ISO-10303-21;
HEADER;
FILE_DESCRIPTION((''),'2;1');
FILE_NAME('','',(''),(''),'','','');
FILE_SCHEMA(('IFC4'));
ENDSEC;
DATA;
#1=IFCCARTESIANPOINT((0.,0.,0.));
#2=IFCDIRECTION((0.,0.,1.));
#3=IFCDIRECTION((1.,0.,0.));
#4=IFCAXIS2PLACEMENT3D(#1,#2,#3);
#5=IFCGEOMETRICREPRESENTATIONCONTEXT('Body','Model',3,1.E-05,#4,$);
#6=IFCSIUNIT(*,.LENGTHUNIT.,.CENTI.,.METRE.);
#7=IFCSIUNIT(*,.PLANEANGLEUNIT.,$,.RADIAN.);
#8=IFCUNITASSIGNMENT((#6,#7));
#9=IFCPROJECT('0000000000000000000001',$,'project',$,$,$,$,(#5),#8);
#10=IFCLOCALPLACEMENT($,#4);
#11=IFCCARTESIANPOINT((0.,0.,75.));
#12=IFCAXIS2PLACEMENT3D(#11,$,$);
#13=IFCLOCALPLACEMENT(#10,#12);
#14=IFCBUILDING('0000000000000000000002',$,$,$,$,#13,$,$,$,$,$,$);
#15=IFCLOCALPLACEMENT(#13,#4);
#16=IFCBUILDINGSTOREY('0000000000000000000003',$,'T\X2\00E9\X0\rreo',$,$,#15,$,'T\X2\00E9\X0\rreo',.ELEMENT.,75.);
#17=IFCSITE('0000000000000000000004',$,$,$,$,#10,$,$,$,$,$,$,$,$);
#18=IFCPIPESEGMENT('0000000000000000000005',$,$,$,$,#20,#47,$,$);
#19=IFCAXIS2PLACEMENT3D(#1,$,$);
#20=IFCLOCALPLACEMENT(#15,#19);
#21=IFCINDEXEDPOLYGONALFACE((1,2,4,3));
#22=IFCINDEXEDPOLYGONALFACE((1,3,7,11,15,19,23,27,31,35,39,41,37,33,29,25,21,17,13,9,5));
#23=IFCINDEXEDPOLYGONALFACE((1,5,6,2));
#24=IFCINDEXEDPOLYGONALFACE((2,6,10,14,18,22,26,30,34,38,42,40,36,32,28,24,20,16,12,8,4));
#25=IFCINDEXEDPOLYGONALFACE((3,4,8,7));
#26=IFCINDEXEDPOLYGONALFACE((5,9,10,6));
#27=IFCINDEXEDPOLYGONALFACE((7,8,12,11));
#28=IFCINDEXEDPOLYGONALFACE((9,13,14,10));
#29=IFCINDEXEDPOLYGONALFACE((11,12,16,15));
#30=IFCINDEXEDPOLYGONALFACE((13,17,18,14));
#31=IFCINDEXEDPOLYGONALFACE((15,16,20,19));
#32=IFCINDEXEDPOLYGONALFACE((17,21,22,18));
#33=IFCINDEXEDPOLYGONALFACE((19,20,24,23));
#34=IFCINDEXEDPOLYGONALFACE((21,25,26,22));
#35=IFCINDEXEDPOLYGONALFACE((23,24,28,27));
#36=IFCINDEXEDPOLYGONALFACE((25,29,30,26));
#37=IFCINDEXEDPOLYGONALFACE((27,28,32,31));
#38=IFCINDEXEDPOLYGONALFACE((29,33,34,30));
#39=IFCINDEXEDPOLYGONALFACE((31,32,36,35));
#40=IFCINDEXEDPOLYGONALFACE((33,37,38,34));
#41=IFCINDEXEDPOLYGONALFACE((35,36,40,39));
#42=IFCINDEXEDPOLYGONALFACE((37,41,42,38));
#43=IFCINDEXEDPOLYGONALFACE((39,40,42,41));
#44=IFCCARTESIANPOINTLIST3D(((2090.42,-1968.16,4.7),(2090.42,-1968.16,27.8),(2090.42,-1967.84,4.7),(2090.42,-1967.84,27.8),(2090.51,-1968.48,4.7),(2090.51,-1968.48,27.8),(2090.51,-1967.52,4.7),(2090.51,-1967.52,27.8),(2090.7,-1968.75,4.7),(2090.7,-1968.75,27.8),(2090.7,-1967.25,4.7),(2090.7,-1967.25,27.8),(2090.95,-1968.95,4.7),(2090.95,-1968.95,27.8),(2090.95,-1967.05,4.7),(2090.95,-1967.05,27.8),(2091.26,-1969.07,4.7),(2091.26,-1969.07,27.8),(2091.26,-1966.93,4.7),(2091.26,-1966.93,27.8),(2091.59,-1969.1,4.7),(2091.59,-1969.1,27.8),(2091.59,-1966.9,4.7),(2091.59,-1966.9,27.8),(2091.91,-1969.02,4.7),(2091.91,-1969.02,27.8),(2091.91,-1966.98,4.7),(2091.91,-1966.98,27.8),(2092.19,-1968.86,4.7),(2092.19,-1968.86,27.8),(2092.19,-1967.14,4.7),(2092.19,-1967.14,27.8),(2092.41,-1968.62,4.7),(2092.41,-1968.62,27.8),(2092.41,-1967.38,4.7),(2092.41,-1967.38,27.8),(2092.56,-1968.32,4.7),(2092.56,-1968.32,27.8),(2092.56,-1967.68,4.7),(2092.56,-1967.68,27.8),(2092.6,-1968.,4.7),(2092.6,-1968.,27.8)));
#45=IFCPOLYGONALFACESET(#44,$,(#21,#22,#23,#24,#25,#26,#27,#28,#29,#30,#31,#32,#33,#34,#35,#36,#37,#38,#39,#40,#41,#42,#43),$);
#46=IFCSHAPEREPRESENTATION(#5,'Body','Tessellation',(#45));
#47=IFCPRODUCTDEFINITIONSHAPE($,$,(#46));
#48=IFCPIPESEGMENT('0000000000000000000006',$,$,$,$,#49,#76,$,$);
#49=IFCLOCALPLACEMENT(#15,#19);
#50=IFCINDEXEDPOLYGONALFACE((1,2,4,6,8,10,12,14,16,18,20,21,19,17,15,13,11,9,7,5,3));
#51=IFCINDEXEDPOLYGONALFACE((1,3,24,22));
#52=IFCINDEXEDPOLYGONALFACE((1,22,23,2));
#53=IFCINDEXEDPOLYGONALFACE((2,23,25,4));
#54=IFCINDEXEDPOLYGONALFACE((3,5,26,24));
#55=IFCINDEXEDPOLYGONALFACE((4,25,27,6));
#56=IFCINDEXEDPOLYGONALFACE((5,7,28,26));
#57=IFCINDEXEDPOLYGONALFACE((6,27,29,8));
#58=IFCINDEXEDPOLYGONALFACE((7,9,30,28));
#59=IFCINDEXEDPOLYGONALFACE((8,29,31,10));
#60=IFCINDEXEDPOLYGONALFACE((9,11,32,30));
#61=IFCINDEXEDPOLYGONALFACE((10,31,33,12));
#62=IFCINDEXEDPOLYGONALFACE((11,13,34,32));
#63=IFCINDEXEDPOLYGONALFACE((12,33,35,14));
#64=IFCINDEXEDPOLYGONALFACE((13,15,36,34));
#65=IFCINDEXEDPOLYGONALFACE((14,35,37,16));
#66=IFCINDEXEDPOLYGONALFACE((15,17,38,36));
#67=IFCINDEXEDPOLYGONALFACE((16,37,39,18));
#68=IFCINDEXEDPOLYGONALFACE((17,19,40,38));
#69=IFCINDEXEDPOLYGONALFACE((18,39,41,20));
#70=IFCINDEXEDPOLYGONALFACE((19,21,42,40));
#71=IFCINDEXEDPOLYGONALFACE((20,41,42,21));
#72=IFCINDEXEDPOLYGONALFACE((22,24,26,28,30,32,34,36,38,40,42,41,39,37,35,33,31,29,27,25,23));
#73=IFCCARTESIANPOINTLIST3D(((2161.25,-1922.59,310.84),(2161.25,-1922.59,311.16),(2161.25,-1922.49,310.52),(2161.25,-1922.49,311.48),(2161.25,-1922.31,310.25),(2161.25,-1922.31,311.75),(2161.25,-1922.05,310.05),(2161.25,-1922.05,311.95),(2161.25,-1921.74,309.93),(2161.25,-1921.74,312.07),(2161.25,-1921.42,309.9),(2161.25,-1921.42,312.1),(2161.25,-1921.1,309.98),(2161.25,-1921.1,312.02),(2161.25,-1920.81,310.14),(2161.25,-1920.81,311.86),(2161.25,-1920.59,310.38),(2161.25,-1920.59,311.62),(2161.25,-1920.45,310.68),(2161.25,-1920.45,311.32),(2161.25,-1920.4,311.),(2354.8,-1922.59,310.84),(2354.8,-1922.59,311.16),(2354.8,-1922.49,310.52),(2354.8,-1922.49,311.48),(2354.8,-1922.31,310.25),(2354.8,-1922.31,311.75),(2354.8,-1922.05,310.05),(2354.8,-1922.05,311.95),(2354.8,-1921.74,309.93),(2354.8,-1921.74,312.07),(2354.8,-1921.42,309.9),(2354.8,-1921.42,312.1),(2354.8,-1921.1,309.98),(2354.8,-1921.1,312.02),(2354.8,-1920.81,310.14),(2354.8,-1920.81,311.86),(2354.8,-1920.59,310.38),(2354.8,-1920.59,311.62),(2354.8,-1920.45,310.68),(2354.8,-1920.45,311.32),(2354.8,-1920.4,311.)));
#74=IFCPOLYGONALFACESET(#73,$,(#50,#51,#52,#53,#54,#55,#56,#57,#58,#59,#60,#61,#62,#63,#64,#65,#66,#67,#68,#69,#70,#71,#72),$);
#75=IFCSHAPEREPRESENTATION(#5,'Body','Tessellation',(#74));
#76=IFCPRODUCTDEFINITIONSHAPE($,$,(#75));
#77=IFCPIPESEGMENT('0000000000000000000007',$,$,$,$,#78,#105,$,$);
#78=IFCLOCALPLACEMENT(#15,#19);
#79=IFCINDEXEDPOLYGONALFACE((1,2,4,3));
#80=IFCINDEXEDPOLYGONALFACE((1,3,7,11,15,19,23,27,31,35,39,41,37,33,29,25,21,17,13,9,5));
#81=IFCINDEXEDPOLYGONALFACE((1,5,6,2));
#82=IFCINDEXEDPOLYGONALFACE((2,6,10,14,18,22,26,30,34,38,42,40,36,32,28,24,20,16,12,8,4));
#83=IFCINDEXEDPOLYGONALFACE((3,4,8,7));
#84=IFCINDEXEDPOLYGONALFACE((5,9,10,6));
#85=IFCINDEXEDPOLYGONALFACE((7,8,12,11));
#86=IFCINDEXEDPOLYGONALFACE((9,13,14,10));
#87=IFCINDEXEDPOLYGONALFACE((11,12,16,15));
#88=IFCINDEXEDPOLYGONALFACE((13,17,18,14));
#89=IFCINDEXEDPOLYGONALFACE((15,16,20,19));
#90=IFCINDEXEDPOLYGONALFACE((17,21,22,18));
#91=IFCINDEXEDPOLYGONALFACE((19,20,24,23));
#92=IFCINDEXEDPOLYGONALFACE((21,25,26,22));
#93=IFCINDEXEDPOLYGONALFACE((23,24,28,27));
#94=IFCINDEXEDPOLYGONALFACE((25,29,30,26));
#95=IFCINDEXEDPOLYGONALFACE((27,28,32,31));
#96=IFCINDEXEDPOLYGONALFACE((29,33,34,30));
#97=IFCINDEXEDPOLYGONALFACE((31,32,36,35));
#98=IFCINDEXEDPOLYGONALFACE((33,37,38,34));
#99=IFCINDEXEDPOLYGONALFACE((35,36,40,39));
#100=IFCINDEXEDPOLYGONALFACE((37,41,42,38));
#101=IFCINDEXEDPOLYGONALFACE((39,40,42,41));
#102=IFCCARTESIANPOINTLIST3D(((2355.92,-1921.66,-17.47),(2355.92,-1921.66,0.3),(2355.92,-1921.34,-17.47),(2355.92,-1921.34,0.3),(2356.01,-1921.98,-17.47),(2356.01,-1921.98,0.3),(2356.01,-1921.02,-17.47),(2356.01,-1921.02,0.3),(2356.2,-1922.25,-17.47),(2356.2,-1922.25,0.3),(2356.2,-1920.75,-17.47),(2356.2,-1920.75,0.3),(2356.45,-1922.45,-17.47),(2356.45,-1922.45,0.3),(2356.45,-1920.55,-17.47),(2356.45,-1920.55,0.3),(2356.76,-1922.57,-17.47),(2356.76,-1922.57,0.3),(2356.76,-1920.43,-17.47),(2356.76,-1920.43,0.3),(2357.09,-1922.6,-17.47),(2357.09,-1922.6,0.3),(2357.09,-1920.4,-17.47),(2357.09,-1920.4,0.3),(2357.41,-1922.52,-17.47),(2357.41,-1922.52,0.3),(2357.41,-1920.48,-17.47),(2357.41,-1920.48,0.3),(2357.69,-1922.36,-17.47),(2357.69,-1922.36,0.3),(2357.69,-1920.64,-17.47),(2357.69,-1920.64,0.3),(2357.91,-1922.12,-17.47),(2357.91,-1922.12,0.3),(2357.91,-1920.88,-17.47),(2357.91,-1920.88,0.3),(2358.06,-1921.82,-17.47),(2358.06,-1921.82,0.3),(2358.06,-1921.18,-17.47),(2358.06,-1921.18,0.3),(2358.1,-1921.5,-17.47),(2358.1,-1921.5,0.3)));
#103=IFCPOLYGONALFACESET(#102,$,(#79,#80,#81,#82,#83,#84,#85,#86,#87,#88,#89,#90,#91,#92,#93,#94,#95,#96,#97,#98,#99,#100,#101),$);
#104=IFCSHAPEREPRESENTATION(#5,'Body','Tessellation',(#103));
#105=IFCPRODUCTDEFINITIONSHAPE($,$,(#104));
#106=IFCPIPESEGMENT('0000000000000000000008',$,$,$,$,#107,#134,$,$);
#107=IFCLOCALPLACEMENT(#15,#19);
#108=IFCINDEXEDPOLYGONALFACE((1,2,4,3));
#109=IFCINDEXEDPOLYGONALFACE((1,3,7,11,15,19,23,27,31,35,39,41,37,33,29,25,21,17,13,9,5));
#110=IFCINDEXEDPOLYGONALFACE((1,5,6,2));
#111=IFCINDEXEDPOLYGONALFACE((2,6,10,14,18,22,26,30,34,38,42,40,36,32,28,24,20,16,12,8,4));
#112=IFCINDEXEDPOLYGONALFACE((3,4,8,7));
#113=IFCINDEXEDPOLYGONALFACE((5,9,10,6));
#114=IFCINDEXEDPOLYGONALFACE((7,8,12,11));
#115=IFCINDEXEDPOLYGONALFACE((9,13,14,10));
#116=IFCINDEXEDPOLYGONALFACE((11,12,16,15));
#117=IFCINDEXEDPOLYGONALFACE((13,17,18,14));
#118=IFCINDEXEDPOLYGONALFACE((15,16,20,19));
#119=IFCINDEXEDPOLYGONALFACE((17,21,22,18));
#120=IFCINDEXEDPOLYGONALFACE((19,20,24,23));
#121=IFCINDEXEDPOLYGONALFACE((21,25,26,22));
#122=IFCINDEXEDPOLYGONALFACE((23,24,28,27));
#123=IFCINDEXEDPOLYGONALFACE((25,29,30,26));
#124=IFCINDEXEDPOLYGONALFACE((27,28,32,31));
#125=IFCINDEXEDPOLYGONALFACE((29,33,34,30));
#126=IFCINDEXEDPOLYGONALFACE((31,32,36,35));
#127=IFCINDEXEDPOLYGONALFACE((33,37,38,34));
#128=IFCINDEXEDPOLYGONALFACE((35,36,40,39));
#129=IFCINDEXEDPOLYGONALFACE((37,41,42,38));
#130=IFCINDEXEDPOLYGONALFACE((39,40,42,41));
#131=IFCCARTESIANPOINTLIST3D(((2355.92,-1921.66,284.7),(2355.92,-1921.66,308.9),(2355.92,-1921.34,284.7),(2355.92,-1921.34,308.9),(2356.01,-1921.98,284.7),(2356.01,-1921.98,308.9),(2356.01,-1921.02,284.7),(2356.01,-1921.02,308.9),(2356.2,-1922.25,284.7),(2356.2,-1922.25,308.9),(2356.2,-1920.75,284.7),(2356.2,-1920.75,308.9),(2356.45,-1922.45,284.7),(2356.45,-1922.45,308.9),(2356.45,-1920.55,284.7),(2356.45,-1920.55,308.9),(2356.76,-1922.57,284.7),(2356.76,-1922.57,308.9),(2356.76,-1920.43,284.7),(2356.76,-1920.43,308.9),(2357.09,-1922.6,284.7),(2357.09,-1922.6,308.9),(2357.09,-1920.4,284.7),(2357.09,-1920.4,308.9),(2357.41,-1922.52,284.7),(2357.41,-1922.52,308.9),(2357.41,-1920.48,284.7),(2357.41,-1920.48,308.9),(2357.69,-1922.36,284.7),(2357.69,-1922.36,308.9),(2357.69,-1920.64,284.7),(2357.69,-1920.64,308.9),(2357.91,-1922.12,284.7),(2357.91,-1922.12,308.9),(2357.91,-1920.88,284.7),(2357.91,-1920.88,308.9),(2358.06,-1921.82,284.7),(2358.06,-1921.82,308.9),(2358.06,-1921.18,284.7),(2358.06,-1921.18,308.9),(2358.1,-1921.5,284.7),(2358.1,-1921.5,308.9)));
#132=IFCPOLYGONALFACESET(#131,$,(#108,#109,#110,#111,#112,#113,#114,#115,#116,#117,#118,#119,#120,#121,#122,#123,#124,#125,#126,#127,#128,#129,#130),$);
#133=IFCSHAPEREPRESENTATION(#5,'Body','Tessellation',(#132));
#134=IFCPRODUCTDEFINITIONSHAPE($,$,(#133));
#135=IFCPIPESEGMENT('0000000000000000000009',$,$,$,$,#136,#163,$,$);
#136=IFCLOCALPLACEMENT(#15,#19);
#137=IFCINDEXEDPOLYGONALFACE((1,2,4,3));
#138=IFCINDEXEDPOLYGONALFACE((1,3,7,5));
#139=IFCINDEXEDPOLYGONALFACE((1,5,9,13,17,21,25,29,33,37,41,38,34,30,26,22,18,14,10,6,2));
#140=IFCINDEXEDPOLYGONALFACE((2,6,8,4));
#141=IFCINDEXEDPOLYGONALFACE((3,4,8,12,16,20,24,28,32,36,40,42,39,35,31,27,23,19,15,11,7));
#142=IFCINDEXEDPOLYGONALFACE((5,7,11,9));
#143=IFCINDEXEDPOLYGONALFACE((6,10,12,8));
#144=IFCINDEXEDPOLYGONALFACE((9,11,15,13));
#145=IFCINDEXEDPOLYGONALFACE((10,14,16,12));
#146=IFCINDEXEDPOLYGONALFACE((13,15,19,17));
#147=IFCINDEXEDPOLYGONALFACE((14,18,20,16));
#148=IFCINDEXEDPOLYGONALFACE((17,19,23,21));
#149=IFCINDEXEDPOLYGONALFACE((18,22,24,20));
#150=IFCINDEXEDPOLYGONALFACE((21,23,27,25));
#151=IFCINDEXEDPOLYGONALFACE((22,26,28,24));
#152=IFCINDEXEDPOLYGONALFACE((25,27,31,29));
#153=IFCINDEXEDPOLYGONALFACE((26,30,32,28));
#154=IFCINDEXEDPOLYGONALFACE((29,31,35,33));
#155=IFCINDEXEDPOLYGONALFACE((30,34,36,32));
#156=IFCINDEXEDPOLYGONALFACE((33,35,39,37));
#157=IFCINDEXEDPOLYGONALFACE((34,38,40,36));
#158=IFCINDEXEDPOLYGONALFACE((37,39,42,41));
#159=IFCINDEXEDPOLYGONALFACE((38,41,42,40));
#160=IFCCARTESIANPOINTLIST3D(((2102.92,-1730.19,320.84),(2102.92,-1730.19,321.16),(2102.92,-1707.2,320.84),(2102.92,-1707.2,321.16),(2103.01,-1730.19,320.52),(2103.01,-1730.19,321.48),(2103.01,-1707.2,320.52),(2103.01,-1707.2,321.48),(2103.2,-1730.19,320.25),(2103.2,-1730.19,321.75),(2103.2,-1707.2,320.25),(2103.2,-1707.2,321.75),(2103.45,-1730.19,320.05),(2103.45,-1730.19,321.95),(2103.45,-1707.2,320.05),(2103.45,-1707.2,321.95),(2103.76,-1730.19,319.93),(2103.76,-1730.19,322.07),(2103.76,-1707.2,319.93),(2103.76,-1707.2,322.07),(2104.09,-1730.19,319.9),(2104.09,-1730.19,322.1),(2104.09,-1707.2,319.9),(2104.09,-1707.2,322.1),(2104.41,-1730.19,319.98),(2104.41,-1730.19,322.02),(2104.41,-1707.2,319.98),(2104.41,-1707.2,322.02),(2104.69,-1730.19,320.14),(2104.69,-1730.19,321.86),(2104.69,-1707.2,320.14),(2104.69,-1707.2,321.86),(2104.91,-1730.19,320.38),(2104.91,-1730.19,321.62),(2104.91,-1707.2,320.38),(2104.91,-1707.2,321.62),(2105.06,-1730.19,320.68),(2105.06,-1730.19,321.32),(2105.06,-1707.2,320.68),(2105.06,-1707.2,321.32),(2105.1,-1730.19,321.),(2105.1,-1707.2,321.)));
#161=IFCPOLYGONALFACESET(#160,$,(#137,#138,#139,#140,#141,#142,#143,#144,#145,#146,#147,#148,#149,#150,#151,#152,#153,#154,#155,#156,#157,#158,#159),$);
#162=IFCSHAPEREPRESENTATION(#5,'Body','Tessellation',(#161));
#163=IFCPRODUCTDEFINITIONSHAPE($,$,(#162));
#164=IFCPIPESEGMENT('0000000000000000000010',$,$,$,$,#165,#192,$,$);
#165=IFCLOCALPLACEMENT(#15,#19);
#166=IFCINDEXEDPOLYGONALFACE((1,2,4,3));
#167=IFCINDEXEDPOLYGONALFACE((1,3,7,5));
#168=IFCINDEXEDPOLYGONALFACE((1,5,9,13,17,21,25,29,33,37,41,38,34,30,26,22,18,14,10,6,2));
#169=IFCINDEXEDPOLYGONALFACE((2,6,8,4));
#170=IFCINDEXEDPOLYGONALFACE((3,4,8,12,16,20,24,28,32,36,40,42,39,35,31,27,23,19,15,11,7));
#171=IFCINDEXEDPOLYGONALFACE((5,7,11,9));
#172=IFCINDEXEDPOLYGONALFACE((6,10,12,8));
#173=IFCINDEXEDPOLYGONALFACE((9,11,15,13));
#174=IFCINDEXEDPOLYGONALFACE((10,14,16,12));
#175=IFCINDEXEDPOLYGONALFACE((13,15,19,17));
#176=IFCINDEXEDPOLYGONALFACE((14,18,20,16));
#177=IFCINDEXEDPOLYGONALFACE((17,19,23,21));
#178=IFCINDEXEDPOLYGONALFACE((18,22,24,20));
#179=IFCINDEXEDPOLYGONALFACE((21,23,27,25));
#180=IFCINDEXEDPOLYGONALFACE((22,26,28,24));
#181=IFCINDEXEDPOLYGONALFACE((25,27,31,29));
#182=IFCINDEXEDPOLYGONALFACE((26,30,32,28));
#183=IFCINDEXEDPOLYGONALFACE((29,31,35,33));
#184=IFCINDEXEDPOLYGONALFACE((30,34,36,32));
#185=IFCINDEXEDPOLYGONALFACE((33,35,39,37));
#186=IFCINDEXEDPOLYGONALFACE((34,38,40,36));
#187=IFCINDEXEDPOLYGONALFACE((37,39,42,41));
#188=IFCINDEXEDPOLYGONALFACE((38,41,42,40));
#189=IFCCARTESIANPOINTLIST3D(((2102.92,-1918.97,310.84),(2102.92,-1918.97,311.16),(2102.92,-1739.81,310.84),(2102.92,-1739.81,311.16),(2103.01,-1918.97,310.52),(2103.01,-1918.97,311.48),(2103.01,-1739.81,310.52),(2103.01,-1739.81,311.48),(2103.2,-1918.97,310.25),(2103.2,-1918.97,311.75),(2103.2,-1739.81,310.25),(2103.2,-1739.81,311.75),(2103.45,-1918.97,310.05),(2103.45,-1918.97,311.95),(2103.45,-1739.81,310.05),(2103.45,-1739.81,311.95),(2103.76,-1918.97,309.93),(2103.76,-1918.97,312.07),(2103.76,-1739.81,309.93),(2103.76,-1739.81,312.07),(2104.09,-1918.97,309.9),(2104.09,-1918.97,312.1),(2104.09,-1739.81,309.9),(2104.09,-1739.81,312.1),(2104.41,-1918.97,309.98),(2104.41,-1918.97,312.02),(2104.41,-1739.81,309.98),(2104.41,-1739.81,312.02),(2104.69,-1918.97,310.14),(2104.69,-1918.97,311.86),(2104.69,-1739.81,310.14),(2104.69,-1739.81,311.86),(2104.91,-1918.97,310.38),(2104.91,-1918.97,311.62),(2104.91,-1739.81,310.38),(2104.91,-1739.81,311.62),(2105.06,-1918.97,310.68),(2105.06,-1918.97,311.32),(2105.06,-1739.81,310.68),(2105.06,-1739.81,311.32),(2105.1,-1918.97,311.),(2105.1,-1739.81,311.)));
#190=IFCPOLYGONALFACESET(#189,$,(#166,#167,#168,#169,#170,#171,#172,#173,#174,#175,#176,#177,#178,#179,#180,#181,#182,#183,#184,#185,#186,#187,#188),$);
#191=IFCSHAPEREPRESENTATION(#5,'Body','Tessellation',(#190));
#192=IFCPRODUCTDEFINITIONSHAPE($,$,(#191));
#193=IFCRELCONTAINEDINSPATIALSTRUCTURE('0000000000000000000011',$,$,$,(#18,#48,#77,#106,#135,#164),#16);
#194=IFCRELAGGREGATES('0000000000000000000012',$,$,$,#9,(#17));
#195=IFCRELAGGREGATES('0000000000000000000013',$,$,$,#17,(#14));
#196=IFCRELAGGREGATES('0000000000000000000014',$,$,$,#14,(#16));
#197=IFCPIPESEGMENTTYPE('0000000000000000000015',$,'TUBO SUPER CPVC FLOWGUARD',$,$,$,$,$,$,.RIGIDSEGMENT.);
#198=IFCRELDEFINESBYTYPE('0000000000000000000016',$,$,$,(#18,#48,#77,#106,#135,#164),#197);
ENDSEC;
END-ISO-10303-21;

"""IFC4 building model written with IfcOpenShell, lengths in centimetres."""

from ifc_helpers import new_model, si_unit, frame, origin_with_axes, origin_2d_with_axis, place, context, project, spatial, circle, extrude, type_object, element, save


model = new_model("IFC4")

# Units and contexts
model_context = context("Model", 3, precision=1e-05, world=origin_with_axes(), identifier="Body")
ifc_project = project(units=[si_unit("LENGTHUNIT", "METRE", prefix="CENTI"), si_unit("PLANEANGLEUNIT", "RADIAN")], contexts=[model_context])

# Site, building, storey
site_placement = place(None, origin_with_axes())
site = spatial("IfcSite", under=ifc_project, at=site_placement)
building_placement = place(site_placement, frame((0.0, 0.0, 75.0)))
building = spatial("IfcBuilding", under=site, at=building_placement)
storey_placement = place(building_placement, origin_with_axes())
storey = spatial("IfcBuildingStorey", under=building, at=storey_placement, Name="Térreo", LongName="Térreo", CompositionType="ELEMENT", Elevation=75.0)

# Pipe segments
pipe_segment_type_1 = type_object("IfcPipeSegmentType", Name="TUBO SUPER CPVC FLOWGUARD", PredefinedType="RIGIDSEGMENT")
pipe_segment_1_placement = place(storey_placement, frame((2091.5, -1968.0, 27.8), z_axis=(0.0, 0.0, 1.0), x_axis=(1.0, 0.0, 0.0)))
element("IfcPipeSegment", 1, at=pipe_segment_1_placement, inside=storey, type_object=pipe_segment_type_1, context=model_context, shape_type="SolidModel", body=[
    extrude(circle(Radius=1.1, at=origin_2d_with_axis()), frame((0.0, 0.0, -23.1), z_axis=(0.0, 0.0, 1.0), x_axis=(1.0, 0.0, 0.0)), (0.0, 0.0, 1.0), 23.1),
])
pipe_segment_2_placement = place(storey_placement, frame((2258.03, -1921.5, 312.1), z_axis=(0.0, 0.0, 1.0), x_axis=(1.0, 0.0, 0.0)))
element("IfcPipeSegment", 2, at=pipe_segment_2_placement, inside=storey, type_object=pipe_segment_type_1, context=model_context, shape_type="SolidModel", body=[
    extrude(circle(Radius=1.1, at=origin_2d_with_axis()), frame((-96.78, 0.0, -1.1), z_axis=(1.0, 0.0, 0.0), x_axis=(0.0, 1.0, 0.0)), (0.0, 0.0, 1.0), 193.55),
])
pipe_segment_3_placement = place(storey_placement, frame((2357.0, -1921.5, 0.3), z_axis=(0.0, 0.0, 1.0), x_axis=(1.0, 0.0, 0.0)))
element("IfcPipeSegment", 3, at=pipe_segment_3_placement, inside=storey, type_object=pipe_segment_type_1, context=model_context, shape_type="SolidModel", body=[
    extrude(circle(Radius=1.1, at=origin_2d_with_axis()), frame((0.0, 0.0, 0.0), z_axis=(0.0, 0.0, -1.0), x_axis=(1.0, 0.0, 0.0)), (0.0, 0.0, 1.0), 17.77),
])
pipe_segment_4_placement = place(storey_placement, frame((2357.0, -1921.5, 308.9), z_axis=(0.0, 0.0, 1.0), x_axis=(1.0, 0.0, 0.0)))
element("IfcPipeSegment", 4, at=pipe_segment_4_placement, inside=storey, type_object=pipe_segment_type_1, context=model_context, shape_type="SolidModel", body=[
    extrude(circle(Radius=1.1, at=origin_2d_with_axis()), frame((0.0, 0.0, 0.0), z_axis=(0.0, 0.0, -1.0), x_axis=(1.0, 0.0, 0.0)), (0.0, 0.0, 1.0), 24.2),
])
pipe_segment_5_placement = place(storey_placement, frame((2104.0, -1718.7, 322.1), z_axis=(0.0, 0.0, 1.0), x_axis=(1.0, 0.0, 0.0)))
element("IfcPipeSegment", 5, at=pipe_segment_5_placement, inside=storey, type_object=pipe_segment_type_1, context=model_context, shape_type="SolidModel", body=[
    extrude(circle(Radius=1.1, at=origin_2d_with_axis()), frame((0.0, 11.5, -1.1), z_axis=(0.0, -1.0, 0.0), x_axis=(1.0, 0.0, 0.0)), (0.0, 0.0, 1.0), 22.99),
])
pipe_segment_6_placement = place(storey_placement, frame((2104.0, -1829.39, 312.1), z_axis=(0.0, 0.0, 1.0), x_axis=(1.0, 0.0, 0.0)))
element("IfcPipeSegment", 6, at=pipe_segment_6_placement, inside=storey, type_object=pipe_segment_type_1, context=model_context, shape_type="SolidModel", body=[
    extrude(circle(Radius=1.1, at=origin_2d_with_axis()), frame((0.0, 89.58, -1.1), z_axis=(0.0, -1.0, 0.0), x_axis=(1.0, 0.0, 0.0)), (0.0, 0.0, 1.0), 179.16),
])

save(model, "model.ifc")
